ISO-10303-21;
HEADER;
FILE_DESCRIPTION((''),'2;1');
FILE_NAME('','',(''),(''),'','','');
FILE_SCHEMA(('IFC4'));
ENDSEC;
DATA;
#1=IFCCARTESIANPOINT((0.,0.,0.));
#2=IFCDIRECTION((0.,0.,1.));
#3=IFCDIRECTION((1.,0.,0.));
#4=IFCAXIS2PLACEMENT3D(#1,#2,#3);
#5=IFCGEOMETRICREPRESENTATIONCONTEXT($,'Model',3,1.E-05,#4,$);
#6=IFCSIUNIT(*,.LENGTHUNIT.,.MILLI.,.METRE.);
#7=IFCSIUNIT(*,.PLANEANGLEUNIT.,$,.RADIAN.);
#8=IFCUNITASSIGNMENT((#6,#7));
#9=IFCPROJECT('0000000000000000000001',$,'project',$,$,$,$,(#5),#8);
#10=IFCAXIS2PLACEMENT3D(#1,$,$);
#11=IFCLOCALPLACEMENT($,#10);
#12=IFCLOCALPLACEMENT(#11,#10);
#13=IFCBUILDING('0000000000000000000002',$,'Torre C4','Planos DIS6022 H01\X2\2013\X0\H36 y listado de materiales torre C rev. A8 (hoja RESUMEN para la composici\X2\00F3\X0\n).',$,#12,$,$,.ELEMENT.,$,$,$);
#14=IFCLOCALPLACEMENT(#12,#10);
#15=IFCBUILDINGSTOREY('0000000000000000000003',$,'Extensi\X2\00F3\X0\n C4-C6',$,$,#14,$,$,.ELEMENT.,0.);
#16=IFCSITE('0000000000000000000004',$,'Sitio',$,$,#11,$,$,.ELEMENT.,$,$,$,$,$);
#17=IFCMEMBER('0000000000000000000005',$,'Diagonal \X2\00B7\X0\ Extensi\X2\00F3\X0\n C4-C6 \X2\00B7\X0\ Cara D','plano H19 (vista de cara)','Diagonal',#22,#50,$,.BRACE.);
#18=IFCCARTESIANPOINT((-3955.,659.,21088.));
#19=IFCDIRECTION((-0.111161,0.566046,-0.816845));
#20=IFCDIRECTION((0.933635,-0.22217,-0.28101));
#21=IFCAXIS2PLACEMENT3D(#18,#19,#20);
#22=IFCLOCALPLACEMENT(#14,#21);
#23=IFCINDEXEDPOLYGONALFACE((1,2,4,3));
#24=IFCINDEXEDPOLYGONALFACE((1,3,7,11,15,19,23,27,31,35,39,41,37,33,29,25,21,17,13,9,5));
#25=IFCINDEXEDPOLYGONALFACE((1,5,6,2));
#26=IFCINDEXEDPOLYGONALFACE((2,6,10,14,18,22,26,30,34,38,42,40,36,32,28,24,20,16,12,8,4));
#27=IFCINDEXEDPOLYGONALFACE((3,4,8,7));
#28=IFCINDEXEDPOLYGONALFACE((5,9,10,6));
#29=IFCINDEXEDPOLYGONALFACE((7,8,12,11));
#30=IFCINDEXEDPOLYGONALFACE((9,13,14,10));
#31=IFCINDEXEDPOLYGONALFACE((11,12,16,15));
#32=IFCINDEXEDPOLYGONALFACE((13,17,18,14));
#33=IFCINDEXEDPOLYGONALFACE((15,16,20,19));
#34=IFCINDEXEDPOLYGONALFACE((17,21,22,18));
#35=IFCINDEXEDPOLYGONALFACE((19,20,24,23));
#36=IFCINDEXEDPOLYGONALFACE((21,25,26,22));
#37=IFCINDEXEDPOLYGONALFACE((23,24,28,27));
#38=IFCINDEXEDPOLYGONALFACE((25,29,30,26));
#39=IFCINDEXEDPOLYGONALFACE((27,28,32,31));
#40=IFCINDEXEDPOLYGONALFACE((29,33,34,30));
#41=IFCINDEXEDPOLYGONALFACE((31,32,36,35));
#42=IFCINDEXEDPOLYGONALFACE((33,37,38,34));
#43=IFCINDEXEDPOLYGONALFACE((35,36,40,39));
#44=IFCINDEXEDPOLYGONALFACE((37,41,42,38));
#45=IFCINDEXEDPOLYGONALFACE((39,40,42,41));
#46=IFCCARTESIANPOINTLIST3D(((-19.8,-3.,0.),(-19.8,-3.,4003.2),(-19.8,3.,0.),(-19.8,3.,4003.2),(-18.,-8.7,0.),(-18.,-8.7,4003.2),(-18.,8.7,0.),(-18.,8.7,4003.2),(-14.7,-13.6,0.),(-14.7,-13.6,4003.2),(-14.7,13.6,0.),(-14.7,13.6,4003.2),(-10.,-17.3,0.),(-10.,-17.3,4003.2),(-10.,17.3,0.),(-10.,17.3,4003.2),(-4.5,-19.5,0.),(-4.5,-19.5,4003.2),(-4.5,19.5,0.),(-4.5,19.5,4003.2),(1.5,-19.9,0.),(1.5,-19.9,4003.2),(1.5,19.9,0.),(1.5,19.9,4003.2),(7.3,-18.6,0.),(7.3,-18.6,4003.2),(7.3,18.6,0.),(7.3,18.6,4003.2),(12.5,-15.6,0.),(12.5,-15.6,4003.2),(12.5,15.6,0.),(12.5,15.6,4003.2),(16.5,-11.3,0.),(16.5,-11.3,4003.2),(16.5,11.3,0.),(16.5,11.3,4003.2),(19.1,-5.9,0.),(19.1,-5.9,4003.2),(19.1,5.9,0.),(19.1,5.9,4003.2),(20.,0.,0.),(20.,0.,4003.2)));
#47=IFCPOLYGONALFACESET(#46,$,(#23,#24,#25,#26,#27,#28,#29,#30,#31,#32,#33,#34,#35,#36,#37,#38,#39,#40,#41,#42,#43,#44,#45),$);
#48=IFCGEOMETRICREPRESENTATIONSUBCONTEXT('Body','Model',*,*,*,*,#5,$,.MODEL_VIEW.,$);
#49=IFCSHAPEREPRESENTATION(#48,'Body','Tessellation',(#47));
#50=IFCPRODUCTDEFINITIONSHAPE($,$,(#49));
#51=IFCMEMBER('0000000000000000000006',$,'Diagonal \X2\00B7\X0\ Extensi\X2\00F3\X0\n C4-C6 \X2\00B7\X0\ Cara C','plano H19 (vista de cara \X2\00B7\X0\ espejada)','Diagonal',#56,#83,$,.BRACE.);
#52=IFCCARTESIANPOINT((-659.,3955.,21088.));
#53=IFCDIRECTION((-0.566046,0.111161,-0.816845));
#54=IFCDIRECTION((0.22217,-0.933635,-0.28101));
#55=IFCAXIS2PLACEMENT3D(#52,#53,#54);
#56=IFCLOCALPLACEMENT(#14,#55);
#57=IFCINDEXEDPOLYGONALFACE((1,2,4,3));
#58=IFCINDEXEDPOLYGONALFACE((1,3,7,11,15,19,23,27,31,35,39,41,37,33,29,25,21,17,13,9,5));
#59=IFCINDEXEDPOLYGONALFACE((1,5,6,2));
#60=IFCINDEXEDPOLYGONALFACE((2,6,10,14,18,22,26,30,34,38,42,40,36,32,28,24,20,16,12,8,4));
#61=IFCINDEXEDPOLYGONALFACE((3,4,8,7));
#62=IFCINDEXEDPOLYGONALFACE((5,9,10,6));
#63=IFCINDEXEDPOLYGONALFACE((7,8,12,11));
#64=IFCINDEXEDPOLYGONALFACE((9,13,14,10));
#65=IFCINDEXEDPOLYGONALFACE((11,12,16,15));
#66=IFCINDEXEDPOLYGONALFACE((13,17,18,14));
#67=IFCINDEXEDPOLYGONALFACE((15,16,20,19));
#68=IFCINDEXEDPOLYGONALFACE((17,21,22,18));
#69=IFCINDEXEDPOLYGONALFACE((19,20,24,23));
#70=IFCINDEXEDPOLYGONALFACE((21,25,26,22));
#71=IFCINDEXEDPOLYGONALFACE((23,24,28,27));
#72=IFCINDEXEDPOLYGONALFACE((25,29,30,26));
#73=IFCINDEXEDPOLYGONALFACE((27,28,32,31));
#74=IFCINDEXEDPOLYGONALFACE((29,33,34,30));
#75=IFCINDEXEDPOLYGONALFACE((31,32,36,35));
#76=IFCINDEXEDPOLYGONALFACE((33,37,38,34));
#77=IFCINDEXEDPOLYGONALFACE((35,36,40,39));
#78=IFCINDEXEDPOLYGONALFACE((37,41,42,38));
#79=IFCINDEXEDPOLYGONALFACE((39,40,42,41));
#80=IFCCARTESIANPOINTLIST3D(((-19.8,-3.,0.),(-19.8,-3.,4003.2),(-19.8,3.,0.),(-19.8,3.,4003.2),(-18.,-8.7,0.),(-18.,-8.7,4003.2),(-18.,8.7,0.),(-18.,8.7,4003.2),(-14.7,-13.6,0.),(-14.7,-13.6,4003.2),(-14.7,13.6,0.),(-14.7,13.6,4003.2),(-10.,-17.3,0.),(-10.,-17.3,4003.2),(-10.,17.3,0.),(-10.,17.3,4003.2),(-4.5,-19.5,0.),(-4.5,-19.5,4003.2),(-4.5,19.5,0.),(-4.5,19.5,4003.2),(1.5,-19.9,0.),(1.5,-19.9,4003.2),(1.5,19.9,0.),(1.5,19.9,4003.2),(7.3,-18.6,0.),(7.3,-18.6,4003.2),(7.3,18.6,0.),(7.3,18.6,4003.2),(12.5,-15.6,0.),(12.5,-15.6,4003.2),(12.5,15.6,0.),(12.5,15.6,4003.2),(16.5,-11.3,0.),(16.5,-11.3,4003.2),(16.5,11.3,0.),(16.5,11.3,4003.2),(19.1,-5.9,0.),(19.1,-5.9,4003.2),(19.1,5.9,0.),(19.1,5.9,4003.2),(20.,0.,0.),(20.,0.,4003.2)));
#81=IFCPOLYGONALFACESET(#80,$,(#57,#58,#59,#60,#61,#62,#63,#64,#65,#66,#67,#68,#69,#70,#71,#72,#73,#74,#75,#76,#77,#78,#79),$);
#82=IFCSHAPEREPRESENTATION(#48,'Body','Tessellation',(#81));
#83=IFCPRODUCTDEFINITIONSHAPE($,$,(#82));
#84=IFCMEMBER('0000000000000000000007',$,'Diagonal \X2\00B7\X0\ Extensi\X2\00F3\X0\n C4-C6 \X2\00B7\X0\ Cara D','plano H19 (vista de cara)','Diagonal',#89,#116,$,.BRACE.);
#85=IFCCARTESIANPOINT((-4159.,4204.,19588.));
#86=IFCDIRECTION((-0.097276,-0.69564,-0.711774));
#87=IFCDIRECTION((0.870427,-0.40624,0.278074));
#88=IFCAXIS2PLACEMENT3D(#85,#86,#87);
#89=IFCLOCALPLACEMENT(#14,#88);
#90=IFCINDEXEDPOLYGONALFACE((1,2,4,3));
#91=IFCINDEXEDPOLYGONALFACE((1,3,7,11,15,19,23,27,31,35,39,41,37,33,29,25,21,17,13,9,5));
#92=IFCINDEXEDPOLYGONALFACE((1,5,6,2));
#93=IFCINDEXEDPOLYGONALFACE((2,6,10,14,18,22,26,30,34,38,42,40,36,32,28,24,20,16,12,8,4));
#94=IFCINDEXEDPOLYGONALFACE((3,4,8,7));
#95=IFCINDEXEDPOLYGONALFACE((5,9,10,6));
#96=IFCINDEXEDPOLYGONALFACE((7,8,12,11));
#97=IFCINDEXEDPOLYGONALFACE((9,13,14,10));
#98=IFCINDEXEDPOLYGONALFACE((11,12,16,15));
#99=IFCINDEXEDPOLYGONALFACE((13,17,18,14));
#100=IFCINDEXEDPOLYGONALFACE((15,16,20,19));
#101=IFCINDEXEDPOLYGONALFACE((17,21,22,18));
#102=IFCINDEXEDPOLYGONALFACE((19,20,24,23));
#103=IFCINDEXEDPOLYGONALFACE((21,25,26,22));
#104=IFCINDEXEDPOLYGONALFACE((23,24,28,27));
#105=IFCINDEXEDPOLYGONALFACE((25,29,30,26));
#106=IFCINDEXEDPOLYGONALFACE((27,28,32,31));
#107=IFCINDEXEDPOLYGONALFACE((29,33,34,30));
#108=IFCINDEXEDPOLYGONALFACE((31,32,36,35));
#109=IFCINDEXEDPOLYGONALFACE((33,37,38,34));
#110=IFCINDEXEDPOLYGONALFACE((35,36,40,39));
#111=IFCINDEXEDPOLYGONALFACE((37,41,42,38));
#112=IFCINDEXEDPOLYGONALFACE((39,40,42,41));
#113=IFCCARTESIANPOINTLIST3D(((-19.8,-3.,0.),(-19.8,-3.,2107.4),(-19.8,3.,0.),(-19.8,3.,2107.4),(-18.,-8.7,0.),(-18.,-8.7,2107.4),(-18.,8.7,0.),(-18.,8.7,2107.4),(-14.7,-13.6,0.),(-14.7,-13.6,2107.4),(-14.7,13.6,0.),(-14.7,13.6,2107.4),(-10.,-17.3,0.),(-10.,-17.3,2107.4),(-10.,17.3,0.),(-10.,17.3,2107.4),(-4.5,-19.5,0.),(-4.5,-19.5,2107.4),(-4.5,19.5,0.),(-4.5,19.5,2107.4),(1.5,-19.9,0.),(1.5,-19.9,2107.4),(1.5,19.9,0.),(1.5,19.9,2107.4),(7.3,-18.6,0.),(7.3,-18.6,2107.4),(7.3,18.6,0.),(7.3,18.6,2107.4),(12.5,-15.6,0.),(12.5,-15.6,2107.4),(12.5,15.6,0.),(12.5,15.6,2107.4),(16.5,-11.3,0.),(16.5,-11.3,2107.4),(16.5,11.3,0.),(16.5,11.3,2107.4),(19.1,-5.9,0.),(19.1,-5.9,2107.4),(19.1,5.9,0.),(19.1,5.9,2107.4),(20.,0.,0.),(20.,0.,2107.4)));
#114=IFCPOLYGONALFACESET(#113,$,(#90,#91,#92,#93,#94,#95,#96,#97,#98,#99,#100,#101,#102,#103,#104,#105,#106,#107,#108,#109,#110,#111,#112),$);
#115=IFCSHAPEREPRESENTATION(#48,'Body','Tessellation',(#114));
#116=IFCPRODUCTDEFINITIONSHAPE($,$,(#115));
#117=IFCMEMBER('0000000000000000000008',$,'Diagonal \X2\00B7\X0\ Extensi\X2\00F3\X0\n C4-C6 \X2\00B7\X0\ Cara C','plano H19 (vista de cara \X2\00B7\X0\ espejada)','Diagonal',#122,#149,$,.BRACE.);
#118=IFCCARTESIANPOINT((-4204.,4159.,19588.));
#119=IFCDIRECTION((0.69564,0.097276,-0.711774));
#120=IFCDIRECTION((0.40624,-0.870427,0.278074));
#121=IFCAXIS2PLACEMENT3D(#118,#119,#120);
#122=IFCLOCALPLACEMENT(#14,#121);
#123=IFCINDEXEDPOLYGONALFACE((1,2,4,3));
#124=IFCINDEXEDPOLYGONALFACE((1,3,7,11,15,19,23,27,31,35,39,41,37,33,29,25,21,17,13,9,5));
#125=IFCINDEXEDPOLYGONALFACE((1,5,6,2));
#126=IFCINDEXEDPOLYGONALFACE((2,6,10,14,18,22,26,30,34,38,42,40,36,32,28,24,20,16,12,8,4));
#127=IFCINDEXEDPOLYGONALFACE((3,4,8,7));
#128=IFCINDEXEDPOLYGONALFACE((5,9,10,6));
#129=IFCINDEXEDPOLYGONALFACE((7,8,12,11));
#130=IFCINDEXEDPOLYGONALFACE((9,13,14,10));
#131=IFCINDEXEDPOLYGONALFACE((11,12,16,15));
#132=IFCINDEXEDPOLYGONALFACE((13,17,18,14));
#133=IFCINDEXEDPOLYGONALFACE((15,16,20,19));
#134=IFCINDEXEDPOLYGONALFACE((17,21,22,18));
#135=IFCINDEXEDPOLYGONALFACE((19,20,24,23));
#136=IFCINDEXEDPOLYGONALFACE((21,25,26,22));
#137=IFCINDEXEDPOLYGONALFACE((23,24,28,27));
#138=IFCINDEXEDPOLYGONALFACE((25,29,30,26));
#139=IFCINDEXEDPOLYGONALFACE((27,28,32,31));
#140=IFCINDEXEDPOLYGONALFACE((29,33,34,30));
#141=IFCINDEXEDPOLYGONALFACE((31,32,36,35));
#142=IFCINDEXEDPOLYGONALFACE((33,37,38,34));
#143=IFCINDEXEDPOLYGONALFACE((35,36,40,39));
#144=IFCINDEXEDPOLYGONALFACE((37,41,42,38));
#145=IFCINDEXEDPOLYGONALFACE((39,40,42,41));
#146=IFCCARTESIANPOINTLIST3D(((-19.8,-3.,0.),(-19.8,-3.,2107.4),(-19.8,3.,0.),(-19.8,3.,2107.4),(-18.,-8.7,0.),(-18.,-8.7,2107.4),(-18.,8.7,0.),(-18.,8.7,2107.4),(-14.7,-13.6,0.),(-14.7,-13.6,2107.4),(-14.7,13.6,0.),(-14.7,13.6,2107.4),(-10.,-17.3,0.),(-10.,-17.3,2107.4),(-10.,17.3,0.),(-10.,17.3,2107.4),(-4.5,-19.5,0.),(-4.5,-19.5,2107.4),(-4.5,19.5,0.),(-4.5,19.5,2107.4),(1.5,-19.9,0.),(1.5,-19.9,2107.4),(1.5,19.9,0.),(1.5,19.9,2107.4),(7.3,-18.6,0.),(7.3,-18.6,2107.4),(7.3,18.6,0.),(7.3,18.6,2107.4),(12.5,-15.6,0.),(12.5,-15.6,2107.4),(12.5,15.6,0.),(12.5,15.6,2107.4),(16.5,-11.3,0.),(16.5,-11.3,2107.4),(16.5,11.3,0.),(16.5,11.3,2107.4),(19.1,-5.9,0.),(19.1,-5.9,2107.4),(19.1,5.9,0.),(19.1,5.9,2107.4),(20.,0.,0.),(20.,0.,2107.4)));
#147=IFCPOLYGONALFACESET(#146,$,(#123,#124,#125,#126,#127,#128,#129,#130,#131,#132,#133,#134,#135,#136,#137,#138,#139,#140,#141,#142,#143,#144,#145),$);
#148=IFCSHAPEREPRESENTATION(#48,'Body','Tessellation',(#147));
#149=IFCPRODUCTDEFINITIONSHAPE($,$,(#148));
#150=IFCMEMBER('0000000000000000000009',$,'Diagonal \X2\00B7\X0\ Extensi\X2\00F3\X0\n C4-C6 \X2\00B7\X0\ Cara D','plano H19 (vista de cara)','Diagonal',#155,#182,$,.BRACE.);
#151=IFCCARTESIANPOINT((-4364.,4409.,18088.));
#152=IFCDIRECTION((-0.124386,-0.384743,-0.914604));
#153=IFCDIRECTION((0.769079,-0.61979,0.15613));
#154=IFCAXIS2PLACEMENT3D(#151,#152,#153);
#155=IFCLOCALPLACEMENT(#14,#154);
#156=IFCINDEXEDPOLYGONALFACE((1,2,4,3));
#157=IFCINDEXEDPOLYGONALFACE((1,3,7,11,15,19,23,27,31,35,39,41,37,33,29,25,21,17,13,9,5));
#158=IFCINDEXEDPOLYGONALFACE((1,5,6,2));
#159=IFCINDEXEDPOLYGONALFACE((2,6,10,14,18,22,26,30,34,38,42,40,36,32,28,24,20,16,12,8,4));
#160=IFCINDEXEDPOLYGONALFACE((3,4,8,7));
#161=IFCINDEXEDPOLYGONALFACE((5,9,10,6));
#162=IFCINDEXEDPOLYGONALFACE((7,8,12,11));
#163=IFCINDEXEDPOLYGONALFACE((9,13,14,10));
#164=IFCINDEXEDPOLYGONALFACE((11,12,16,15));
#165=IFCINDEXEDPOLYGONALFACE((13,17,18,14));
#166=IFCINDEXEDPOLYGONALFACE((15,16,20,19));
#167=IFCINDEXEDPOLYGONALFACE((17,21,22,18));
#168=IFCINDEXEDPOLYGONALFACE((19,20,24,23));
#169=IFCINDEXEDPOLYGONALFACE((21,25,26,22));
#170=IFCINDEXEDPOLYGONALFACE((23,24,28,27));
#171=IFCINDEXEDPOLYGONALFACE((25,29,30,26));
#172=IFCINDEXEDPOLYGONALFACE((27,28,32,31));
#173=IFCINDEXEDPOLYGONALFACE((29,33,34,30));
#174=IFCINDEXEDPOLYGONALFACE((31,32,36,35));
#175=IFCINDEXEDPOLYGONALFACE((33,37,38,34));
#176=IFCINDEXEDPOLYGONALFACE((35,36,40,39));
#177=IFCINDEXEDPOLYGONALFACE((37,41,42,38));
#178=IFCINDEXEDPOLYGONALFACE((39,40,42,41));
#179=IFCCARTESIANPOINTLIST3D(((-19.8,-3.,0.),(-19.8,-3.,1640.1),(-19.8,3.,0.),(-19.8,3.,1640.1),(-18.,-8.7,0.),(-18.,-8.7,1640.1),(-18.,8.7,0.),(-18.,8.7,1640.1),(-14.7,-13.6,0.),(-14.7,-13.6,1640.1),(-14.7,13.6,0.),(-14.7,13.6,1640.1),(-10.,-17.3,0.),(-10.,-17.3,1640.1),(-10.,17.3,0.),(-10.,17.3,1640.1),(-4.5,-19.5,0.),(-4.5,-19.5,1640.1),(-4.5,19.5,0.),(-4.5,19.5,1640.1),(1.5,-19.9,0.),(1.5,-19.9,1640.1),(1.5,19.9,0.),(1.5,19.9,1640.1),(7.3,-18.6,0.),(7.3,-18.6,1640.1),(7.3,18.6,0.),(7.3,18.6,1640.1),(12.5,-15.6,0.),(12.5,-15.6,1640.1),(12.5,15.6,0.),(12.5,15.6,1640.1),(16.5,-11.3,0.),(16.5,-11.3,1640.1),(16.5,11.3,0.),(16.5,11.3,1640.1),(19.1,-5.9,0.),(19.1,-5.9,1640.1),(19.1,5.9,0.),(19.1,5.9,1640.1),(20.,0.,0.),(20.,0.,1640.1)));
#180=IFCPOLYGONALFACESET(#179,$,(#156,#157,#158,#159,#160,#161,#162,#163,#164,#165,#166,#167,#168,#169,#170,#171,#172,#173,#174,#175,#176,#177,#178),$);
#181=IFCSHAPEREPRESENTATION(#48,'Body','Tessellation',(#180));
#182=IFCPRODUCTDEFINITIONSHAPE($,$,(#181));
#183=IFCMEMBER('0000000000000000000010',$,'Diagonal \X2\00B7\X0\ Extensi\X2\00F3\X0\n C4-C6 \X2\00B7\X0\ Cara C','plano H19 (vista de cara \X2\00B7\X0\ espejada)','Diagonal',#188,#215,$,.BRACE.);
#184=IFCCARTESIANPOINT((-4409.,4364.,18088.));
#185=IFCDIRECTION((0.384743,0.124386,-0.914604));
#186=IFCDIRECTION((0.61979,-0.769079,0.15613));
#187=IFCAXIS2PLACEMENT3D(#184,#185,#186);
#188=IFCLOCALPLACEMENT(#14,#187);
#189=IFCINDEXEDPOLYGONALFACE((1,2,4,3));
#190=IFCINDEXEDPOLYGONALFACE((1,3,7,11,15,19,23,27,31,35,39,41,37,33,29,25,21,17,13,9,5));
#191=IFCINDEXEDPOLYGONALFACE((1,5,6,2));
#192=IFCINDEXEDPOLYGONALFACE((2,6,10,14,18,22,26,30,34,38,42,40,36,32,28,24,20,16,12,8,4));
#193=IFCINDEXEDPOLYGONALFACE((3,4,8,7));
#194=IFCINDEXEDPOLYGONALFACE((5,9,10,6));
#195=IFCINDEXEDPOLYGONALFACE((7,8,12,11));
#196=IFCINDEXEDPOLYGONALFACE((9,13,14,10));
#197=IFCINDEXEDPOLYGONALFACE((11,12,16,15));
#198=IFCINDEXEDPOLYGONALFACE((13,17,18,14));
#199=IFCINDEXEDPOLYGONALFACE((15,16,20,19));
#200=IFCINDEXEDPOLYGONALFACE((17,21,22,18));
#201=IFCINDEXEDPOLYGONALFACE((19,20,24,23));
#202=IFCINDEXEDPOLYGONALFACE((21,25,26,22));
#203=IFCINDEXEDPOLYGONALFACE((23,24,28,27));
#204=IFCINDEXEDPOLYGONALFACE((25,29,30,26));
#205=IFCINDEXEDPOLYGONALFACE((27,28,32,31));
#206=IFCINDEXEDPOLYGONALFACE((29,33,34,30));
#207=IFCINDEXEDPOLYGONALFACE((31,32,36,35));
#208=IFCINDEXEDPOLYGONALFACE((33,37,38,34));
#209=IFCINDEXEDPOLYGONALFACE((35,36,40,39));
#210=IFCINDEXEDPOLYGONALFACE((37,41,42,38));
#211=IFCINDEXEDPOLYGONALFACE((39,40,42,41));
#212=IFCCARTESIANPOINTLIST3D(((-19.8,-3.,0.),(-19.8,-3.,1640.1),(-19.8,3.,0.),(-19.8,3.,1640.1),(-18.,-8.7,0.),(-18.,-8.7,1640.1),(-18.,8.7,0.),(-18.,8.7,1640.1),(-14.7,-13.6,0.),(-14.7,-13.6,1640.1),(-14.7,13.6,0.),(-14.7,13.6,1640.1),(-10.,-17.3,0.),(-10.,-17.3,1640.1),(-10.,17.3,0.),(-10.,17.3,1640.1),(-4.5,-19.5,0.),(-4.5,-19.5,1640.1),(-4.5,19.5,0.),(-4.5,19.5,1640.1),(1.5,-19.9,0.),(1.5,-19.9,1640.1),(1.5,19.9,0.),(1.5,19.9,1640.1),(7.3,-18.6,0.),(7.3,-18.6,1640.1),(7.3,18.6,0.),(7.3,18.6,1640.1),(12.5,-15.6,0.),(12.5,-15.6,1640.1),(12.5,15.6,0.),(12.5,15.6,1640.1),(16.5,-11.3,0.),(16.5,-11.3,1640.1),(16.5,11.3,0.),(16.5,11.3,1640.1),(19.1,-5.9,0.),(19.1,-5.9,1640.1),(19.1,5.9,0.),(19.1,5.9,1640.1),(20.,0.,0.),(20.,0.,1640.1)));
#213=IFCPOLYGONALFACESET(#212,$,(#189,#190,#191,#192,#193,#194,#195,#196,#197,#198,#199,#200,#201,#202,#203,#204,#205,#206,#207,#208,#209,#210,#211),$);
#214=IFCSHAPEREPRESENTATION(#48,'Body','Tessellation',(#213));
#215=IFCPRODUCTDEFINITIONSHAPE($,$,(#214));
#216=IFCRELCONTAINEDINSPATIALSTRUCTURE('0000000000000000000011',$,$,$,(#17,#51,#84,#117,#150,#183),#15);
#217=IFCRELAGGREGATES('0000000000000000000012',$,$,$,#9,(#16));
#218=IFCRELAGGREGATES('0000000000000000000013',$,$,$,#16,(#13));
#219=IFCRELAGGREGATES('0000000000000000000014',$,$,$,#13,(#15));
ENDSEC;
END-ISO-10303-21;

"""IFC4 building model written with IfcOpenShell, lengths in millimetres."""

from ifc_helpers import new_model, si_unit, frame, origin, origin_with_axes, place, context, subcontext, project, spatial, circle, extrude, element, save


model = new_model("IFC4")

# Units and contexts
model_context = context("Model", 3, precision=1e-05, world=origin_with_axes())
body_context = subcontext(model_context, "Body", "Model", "MODEL_VIEW")
ifc_project = project(units=[si_unit("LENGTHUNIT", "METRE", prefix="MILLI"), si_unit("PLANEANGLEUNIT", "RADIAN")], contexts=[model_context])

# Site, building, storey
site_placement = place(None, origin())
site = spatial("IfcSite", under=ifc_project, at=site_placement, Name="Sitio", CompositionType="ELEMENT")
building_placement = place(site_placement, origin())
building = spatial("IfcBuilding", under=site, at=building_placement, Name="Torre C4", Description="Planos DIS6022 H01–H36 y listado de materiales torre C rev. A8 (hoja RESUMEN para la composición).", CompositionType="ELEMENT")
storey_placement = place(building_placement, origin())
storey = spatial("IfcBuildingStorey", under=building, at=storey_placement, Name="Extensión C4-C6", CompositionType="ELEMENT", Elevation=0.0)

# Members
for number, where, z_axis, x_axis, name, description in (
    (1, (-3955.0, 659.0, 21088.0), (-0.111161, 0.566046, -0.816845), (0.933635, -0.22217, -0.28101), "Diagonal · Extensión C4-C6 · Cara D", "plano H19 (vista de cara)"),
    (2, (-659.0, 3955.0, 21088.0), (-0.566046, 0.111161, -0.816845), (0.22217, -0.933635, -0.28101), "Diagonal · Extensión C4-C6 · Cara C", "plano H19 (vista de cara · espejada)"),
):
    element("IfcMember", number, at=place(storey_placement, frame(where, z_axis=z_axis, x_axis=x_axis)), inside=storey, Name=name, Description=description, ObjectType="Diagonal", PredefinedType="BRACE", context=body_context, shape_type="SweptSolid", body=[
        extrude(circle(Radius=20.0), None, (0.0, 0.0, 1.0), 4003.2),
    ])
for number, where, z_axis, x_axis, name, description in (
    (3, (-4159.0, 4204.0, 19588.0), (-0.097276, -0.69564, -0.711774), (0.870427, -0.40624, 0.278074), "Diagonal · Extensión C4-C6 · Cara D", "plano H19 (vista de cara)"),
    (4, (-4204.0, 4159.0, 19588.0), (0.69564, 0.097276, -0.711774), (0.40624, -0.870427, 0.278074), "Diagonal · Extensión C4-C6 · Cara C", "plano H19 (vista de cara · espejada)"),
):
    element("IfcMember", number, at=place(storey_placement, frame(where, z_axis=z_axis, x_axis=x_axis)), inside=storey, Name=name, Description=description, ObjectType="Diagonal", PredefinedType="BRACE", context=body_context, shape_type="SweptSolid", body=[
        extrude(circle(Radius=20.0), None, (0.0, 0.0, 1.0), 2107.4),
    ])
for number, where, z_axis, x_axis, name, description in (
    (5, (-4364.0, 4409.0, 18088.0), (-0.124386, -0.384743, -0.914604), (0.769079, -0.61979, 0.15613), "Diagonal · Extensión C4-C6 · Cara D", "plano H19 (vista de cara)"),
    (6, (-4409.0, 4364.0, 18088.0), (0.384743, 0.124386, -0.914604), (0.61979, -0.769079, 0.15613), "Diagonal · Extensión C4-C6 · Cara C", "plano H19 (vista de cara · espejada)"),
):
    element("IfcMember", number, at=place(storey_placement, frame(where, z_axis=z_axis, x_axis=x_axis)), inside=storey, Name=name, Description=description, ObjectType="Diagonal", PredefinedType="BRACE", context=body_context, shape_type="SweptSolid", body=[
        extrude(circle(Radius=20.0), None, (0.0, 0.0, 1.0), 1640.1),
    ])

save(model, "model.ifc")
